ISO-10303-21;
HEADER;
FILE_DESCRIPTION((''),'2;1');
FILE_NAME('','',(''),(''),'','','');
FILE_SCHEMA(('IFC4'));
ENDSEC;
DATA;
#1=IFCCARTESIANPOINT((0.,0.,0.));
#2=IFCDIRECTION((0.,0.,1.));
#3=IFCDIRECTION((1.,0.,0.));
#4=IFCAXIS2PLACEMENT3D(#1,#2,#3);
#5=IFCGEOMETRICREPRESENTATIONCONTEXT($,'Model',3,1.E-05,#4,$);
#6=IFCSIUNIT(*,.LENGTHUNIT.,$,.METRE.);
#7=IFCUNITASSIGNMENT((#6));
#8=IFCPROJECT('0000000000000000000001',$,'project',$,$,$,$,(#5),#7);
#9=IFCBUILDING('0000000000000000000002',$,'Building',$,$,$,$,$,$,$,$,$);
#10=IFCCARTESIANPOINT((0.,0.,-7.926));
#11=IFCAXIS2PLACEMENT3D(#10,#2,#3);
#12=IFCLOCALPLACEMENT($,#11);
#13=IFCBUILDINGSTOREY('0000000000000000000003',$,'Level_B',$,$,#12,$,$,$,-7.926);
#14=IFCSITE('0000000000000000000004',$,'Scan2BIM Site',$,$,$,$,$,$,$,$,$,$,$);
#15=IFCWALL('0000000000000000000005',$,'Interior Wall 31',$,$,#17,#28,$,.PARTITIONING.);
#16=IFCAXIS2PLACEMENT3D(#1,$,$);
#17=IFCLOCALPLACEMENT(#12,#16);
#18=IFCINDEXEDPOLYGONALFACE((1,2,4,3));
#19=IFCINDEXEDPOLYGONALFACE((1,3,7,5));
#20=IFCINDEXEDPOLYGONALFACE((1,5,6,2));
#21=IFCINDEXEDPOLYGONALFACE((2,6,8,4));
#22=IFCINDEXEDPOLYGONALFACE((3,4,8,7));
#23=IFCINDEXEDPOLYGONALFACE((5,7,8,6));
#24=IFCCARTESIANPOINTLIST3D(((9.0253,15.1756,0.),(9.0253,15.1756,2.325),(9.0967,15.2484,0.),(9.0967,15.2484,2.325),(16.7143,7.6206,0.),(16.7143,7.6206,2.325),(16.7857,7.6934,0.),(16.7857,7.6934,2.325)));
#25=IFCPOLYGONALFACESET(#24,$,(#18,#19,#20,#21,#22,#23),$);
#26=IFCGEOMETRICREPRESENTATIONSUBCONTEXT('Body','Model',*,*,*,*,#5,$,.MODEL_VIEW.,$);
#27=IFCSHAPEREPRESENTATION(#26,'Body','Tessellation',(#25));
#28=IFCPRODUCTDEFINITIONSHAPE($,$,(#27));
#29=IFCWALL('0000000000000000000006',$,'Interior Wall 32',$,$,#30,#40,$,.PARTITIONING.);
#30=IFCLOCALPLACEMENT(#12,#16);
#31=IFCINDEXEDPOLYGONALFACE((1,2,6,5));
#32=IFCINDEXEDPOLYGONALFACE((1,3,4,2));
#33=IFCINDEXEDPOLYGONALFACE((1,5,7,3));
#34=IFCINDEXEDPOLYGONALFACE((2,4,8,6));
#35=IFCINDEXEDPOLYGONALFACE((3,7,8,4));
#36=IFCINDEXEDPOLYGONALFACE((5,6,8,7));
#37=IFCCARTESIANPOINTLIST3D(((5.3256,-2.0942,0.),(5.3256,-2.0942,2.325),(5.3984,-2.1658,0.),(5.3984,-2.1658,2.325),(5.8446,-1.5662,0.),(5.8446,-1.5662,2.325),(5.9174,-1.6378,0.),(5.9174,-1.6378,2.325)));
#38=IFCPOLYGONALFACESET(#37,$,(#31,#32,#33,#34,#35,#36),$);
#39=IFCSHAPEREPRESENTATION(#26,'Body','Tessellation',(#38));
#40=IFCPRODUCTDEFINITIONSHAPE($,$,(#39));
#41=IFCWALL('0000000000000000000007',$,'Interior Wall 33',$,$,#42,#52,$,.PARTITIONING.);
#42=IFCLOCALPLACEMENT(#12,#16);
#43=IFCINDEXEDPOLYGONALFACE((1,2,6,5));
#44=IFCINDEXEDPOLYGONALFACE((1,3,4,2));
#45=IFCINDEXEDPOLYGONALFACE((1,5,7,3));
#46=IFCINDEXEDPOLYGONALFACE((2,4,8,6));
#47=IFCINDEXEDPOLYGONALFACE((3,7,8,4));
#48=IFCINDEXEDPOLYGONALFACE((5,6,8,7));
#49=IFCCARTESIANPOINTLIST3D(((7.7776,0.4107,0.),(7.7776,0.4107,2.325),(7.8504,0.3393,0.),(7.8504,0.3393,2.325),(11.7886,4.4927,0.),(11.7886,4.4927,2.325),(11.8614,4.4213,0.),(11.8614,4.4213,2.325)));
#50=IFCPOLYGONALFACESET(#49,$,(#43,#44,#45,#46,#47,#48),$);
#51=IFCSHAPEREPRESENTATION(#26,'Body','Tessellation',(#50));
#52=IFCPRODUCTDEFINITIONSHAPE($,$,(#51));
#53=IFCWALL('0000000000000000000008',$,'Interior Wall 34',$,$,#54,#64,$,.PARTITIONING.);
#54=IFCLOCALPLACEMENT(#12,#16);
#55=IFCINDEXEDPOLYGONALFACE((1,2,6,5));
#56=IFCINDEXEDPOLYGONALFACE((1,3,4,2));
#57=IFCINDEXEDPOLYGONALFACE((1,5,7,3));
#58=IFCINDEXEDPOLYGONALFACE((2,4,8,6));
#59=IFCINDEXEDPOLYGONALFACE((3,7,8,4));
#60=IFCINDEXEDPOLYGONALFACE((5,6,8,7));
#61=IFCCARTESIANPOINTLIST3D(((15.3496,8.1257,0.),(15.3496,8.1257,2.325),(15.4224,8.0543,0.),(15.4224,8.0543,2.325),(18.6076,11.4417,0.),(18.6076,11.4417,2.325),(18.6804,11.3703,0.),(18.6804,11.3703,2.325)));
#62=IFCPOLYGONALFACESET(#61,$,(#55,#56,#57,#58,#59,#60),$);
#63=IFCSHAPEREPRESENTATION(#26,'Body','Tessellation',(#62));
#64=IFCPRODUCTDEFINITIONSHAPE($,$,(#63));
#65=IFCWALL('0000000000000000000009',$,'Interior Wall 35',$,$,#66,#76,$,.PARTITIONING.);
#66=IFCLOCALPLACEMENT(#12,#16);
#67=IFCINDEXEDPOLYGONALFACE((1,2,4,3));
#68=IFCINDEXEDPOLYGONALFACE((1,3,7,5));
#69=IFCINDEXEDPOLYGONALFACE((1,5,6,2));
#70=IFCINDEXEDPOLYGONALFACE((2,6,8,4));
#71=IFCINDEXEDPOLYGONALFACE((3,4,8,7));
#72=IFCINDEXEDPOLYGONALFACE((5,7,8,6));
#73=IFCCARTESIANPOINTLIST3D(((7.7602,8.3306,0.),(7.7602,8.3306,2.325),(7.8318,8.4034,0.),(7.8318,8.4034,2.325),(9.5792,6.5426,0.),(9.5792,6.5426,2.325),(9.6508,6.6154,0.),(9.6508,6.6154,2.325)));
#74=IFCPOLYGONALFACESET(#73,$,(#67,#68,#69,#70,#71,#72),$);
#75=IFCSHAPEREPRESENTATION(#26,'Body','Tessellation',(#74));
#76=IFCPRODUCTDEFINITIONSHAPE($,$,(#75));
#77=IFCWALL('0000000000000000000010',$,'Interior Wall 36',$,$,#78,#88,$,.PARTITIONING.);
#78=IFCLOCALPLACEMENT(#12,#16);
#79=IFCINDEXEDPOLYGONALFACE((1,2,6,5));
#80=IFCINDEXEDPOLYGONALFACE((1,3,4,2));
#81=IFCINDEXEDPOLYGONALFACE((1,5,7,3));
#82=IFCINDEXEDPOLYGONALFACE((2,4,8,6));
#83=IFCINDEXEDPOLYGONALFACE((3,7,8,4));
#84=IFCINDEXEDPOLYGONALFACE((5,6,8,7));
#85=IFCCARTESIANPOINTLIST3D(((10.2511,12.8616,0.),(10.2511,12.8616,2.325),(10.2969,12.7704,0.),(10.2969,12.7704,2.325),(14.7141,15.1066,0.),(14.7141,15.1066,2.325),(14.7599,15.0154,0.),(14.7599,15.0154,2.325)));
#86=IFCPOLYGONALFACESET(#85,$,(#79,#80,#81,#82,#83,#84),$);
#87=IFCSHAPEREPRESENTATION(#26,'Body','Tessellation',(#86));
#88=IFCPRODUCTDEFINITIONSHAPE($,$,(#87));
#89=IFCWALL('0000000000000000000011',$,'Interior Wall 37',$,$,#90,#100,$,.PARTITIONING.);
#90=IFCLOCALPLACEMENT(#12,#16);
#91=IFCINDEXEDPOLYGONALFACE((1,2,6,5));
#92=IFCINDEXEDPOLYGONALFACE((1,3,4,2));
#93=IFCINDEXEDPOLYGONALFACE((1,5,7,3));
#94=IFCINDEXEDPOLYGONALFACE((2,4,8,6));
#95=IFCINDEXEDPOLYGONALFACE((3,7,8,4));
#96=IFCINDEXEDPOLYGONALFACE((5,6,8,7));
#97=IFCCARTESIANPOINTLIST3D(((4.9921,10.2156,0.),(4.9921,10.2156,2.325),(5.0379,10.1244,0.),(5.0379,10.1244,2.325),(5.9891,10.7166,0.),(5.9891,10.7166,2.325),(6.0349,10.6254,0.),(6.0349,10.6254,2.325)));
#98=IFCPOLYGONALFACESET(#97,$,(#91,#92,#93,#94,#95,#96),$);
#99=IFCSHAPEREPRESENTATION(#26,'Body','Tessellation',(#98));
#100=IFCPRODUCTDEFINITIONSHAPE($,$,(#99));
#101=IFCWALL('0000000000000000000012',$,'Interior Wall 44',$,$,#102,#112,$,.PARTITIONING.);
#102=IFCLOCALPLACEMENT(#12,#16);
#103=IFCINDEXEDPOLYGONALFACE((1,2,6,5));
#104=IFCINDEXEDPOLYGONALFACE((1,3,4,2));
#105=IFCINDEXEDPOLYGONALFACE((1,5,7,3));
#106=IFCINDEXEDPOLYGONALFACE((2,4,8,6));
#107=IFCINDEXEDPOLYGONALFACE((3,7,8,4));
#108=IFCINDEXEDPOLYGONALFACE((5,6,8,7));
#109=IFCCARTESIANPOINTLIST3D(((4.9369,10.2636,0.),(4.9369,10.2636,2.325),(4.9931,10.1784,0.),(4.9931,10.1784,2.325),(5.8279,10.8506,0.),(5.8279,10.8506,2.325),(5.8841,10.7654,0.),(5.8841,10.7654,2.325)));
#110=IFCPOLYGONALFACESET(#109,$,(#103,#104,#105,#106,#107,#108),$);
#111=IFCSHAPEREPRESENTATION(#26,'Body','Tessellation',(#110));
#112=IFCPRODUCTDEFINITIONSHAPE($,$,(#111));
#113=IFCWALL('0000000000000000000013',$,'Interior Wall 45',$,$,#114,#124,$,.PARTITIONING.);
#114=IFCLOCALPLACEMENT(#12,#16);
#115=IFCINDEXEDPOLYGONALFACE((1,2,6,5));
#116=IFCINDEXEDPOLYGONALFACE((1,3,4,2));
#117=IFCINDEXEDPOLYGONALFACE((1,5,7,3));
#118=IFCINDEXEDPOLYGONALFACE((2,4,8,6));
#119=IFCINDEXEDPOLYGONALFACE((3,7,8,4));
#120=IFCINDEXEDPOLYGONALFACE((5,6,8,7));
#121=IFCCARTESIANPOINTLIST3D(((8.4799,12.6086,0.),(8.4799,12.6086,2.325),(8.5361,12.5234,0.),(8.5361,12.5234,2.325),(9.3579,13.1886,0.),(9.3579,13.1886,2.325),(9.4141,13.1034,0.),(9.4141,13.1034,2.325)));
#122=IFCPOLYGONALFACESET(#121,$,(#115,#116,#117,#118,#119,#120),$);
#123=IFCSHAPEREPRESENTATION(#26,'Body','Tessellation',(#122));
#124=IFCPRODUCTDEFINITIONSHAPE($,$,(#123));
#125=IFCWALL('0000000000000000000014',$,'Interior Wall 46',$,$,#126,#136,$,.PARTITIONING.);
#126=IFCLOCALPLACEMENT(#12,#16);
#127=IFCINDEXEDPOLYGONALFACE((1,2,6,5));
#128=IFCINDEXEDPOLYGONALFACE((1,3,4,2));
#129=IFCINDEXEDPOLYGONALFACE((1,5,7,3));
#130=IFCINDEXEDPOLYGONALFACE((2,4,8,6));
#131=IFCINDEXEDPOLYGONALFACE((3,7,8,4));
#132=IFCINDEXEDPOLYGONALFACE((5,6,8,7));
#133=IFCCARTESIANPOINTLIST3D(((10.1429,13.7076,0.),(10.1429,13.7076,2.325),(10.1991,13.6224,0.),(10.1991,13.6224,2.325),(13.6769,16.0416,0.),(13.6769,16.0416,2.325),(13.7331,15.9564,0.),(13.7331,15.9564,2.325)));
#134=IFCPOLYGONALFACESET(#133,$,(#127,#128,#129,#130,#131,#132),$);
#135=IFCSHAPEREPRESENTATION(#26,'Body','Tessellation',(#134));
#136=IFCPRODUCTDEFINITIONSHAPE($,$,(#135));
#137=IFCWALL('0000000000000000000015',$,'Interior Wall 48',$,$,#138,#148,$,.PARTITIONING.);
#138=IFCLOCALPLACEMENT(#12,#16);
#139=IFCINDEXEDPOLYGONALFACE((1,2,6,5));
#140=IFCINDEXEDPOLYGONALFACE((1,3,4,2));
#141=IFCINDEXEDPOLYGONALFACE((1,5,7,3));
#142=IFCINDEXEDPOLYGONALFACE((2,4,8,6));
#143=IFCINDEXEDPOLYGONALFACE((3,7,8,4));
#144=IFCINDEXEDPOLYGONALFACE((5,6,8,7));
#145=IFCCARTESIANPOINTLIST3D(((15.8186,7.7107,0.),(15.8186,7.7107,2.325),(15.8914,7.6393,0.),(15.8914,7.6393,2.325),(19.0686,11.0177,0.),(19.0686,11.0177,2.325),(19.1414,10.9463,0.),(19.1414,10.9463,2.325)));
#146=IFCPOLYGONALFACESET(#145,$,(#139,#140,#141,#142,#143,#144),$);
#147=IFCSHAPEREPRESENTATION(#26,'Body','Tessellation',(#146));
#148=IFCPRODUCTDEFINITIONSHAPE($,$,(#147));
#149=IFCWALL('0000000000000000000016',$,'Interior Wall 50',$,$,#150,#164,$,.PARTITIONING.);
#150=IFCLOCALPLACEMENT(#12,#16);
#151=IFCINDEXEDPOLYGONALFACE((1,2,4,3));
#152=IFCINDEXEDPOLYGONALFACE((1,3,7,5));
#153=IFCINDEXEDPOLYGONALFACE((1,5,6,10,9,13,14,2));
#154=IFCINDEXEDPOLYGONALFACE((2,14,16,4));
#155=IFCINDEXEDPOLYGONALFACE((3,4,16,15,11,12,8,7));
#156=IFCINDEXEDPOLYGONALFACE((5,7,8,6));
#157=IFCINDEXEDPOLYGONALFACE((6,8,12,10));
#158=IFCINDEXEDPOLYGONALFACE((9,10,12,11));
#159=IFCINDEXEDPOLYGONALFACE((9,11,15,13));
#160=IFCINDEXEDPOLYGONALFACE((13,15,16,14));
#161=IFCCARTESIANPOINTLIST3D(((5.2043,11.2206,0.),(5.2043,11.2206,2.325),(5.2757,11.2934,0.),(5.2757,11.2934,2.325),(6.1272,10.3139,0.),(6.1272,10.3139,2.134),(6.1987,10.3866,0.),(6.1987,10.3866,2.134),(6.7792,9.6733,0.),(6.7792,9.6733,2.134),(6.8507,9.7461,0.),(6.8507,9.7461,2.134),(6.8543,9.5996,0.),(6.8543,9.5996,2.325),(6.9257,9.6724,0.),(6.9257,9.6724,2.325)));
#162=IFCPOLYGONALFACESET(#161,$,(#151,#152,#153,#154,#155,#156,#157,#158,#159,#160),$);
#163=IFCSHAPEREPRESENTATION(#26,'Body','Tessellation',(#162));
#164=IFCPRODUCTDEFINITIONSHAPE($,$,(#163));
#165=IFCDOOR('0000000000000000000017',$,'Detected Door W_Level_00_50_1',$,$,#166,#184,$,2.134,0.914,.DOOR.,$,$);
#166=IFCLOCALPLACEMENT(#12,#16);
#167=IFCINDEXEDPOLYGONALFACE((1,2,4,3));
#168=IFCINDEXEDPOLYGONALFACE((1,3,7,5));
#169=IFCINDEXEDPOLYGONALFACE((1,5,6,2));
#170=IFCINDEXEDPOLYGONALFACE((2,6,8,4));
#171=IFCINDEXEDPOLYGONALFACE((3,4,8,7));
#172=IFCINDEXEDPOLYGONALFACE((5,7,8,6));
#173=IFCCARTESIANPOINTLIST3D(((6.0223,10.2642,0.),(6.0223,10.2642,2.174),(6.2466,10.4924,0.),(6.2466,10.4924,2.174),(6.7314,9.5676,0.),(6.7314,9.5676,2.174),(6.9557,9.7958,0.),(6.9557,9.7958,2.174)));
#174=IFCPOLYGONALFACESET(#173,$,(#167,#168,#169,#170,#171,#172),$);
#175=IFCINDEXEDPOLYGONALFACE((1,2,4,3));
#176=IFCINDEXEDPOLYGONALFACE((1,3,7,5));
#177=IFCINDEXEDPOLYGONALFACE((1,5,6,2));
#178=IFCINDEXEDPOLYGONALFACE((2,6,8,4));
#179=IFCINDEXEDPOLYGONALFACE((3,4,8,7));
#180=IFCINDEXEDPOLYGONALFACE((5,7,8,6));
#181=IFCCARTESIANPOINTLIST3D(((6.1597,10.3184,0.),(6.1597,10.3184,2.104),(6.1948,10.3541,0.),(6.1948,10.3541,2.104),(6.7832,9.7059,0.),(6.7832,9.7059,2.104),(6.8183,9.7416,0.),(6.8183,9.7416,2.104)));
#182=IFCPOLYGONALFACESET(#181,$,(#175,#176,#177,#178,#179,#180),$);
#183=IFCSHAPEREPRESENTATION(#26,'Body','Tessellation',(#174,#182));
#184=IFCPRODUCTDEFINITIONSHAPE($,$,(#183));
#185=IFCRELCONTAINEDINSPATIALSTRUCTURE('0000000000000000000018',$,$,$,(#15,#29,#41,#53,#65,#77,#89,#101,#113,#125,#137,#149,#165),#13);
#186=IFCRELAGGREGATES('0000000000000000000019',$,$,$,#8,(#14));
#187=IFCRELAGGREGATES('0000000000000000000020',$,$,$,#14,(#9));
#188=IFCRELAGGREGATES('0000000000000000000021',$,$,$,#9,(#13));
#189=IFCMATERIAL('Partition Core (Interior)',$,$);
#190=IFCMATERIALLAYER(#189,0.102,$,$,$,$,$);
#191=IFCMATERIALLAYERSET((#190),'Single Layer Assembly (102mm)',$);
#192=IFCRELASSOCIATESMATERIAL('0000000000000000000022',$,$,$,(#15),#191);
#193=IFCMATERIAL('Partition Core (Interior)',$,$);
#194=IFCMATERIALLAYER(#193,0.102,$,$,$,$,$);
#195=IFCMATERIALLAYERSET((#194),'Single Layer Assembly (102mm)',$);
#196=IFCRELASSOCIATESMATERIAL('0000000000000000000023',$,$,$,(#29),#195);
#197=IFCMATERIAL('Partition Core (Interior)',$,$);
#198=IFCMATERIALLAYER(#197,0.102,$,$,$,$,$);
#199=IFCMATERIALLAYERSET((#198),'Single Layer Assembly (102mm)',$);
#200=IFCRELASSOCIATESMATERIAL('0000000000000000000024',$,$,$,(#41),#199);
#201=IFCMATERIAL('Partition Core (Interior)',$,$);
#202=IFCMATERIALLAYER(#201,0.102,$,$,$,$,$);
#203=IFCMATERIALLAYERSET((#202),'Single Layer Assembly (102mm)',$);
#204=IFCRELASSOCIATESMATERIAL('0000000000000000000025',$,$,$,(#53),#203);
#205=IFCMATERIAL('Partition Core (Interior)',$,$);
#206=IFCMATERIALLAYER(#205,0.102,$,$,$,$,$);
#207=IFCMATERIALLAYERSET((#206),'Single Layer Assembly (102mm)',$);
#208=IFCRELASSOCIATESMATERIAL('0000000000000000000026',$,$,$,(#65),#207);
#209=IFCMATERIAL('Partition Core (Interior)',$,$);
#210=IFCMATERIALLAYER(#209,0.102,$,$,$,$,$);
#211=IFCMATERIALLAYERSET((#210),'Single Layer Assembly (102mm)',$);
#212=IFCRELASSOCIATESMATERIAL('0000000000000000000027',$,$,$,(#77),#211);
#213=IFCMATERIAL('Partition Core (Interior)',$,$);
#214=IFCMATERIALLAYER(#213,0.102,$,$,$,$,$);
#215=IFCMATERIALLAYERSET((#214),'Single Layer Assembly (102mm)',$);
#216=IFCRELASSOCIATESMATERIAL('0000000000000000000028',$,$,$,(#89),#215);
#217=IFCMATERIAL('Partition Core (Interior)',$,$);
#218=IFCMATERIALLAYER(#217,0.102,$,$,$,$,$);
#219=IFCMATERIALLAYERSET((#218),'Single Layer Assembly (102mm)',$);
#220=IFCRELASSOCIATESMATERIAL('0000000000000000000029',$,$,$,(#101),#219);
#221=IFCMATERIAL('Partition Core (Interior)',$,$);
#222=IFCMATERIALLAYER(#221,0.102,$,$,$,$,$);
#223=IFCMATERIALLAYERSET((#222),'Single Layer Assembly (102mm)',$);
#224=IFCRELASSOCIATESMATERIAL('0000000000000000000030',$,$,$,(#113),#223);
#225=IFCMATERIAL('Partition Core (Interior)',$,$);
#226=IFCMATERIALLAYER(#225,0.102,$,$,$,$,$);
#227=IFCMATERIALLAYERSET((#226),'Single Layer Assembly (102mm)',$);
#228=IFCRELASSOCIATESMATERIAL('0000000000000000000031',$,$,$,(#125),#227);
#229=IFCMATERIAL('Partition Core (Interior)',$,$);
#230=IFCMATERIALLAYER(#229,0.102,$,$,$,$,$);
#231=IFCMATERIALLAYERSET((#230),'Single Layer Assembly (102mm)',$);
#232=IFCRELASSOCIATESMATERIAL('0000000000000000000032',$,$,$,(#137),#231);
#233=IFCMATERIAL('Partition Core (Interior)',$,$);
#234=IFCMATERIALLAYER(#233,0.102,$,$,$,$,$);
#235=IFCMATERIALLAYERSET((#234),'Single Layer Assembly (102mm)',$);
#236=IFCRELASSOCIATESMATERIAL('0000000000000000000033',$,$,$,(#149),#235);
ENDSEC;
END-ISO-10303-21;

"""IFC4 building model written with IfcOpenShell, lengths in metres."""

from ifc_helpers import new_model, si_unit, frame, origin, origin_with_axes, place, context, subcontext, project, spatial, rectangle, extrude, material, layer, layer_set, element, fill, save


model = new_model("IFC4")

# Units and contexts
model_context = context("Model", 3, precision=1e-05, world=origin_with_axes())
body_context = subcontext(model_context, "Body", "Model", "MODEL_VIEW")
ifc_project = project(units=[si_unit("LENGTHUNIT", "METRE")], contexts=[model_context])

# Site, building, storey
site = spatial("IfcSite", under=ifc_project, Name="Scan2BIM Site")
building = spatial("IfcBuilding", under=site, Name="Building")
storey_placement = place(None, frame((0.0, 0.0, -7.926), z_axis=(0.0, 0.0, 1.0), x_axis=(1.0, 0.0, 0.0)))
storey = spatial("IfcBuildingStorey", under=building, at=storey_placement, Name="Level_B", Elevation=-7.926)

# Walls
ifc_material_1 = material(Name="Partition Core (Interior)")
ifc_layer_1 = layer(ifc_material_1, 0.102)
ifc_layer_set_1 = layer_set([ifc_layer_1], Name="Single Layer Assembly (102mm)")
wall_1_placement = place(storey_placement, frame((12.9055, 11.4345, 0.0), z_axis=(0.0, 0.0, 1.0), x_axis=(-0.713295, 0.700864, 0.0)))
element("IfcWall", 1, at=wall_1_placement, inside=storey, material=ifc_layer_set_1, Name="Interior Wall 31", PredefinedType="PARTITIONING", context=body_context, shape_type="SweptSolid", body=[
    extrude(rectangle(XDim=10.7796, YDim=0.102), origin(), (0.0, 0.0, 1.0), 2.325),
])
ifc_material_2 = material(Name="Partition Core (Interior)")
ifc_layer_2 = layer(ifc_material_2, 0.102)
ifc_layer_set_2 = layer_set([ifc_layer_2], Name="Single Layer Assembly (102mm)")
wall_2_placement = place(storey_placement, frame((5.6215, -1.866, 0.0), z_axis=(0.0, 0.0, 1.0), x_axis=(0.701003, 0.713159, 0.0)))
element("IfcWall", 2, at=wall_2_placement, inside=storey, material=ifc_layer_set_2, Name="Interior Wall 32", PredefinedType="PARTITIONING", context=body_context, shape_type="SweptSolid", body=[
    extrude(rectangle(XDim=0.7404, YDim=0.102), origin(), (0.0, 0.0, 1.0), 2.325),
])
ifc_material_3 = material(Name="Partition Core (Interior)")
ifc_layer_3 = layer(ifc_material_3, 0.102)
ifc_layer_set_3 = layer_set([ifc_layer_3], Name="Single Layer Assembly (102mm)")
wall_3_placement = place(storey_placement, frame((9.8195, 2.416, 0.0), z_axis=(0.0, 0.0, 1.0), x_axis=(0.700876, 0.713283, 0.0)))
element("IfcWall", 3, at=wall_3_placement, inside=storey, material=ifc_layer_set_3, Name="Interior Wall 33", PredefinedType="PARTITIONING", context=body_context, shape_type="SweptSolid", body=[
    extrude(rectangle(XDim=5.7228, YDim=0.102), origin(), (0.0, 0.0, 1.0), 2.325),
])
ifc_material_4 = material(Name="Partition Core (Interior)")
ifc_layer_4 = layer(ifc_material_4, 0.102)
ifc_layer_set_4 = layer_set([ifc_layer_4], Name="Single Layer Assembly (102mm)")
wall_4_placement = place(storey_placement, frame((17.015, 9.748, 0.0), z_axis=(0.0, 0.0, 1.0), x_axis=(0.700841, 0.713318, 0.0)))
element("IfcWall", 4, at=wall_4_placement, inside=storey, material=ifc_layer_set_4, Name="Interior Wall 34", PredefinedType="PARTITIONING", context=body_context, shape_type="SweptSolid", body=[
    extrude(rectangle(XDim=4.6487, YDim=0.102), origin(), (0.0, 0.0, 1.0), 2.325),
])
ifc_material_5 = material(Name="Partition Core (Interior)")
ifc_layer_5 = layer(ifc_material_5, 0.102)
ifc_layer_set_5 = layer_set([ifc_layer_5], Name="Single Layer Assembly (102mm)")
wall_5_placement = place(storey_placement, frame((8.7055, 7.473, 0.0), z_axis=(0.0, 0.0, 1.0), x_axis=(0.713158, -0.701004, 0.0)))
element("IfcWall", 5, at=wall_5_placement, inside=storey, material=ifc_layer_set_5, Name="Interior Wall 35", PredefinedType="PARTITIONING", context=body_context, shape_type="SweptSolid", body=[
    extrude(rectangle(XDim=2.5506, YDim=0.102), origin(), (0.0, 0.0, 1.0), 2.325),
])
ifc_material_6 = material(Name="Partition Core (Interior)")
ifc_layer_6 = layer(ifc_material_6, 0.102)
ifc_layer_set_6 = layer_set([ifc_layer_6], Name="Single Layer Assembly (102mm)")
wall_6_placement = place(storey_placement, frame((12.5055, 13.9385, 0.0), z_axis=(0.0, 0.0, 1.0), x_axis=(-0.893344, -0.449374, 0.0)))
element("IfcWall", 6, at=wall_6_placement, inside=storey, material=ifc_layer_set_6, Name="Interior Wall 36", PredefinedType="PARTITIONING", context=body_context, shape_type="SweptSolid", body=[
    extrude(rectangle(XDim=4.9958, YDim=0.102), origin(), (0.0, 0.0, 1.0), 2.325),
])
ifc_material_7 = material(Name="Partition Core (Interior)")
ifc_layer_7 = layer(ifc_material_7, 0.102)
ifc_layer_set_7 = layer_set([ifc_layer_7], Name="Single Layer Assembly (102mm)")
wall_7_placement = place(storey_placement, frame((5.5135, 10.4205, 0.0), z_axis=(0.0, 0.0, 1.0), x_axis=(-0.893529, -0.449005, 0.0)))
element("IfcWall", 7, at=wall_7_placement, inside=storey, material=ifc_layer_set_7, Name="Interior Wall 37", PredefinedType="PARTITIONING", context=body_context, shape_type="SweptSolid", body=[
    extrude(rectangle(XDim=1.1158, YDim=0.102), origin(), (0.0, 0.0, 1.0), 2.325),
])
ifc_material_8 = material(Name="Partition Core (Interior)")
ifc_layer_8 = layer(ifc_material_8, 0.102)
ifc_layer_set_8 = layer_set([ifc_layer_8], Name="Single Layer Assembly (102mm)")
wall_8_placement = place(storey_placement, frame((5.4105, 10.5145, 0.0), z_axis=(0.0, 0.0, 1.0), x_axis=(0.835066, 0.55015, 0.0)))
element("IfcWall", 8, at=wall_8_placement, inside=storey, material=ifc_layer_set_8, Name="Interior Wall 44", PredefinedType="PARTITIONING", context=body_context, shape_type="SweptSolid", body=[
    extrude(rectangle(XDim=1.067, YDim=0.102), origin(), (0.0, 0.0, 1.0), 2.325),
])
ifc_material_9 = material(Name="Partition Core (Interior)")
ifc_layer_9 = layer(ifc_material_9, 0.102)
ifc_layer_set_9 = layer_set([ifc_layer_9], Name="Single Layer Assembly (102mm)")
wall_9_placement = place(storey_placement, frame((8.947, 12.856, 0.0), z_axis=(0.0, 0.0, 1.0), x_axis=(0.834382, 0.551186, 0.0)))
element("IfcWall", 9, at=wall_9_placement, inside=storey, material=ifc_layer_set_9, Name="Interior Wall 45", PredefinedType="PARTITIONING", context=body_context, shape_type="SweptSolid", body=[
    extrude(rectangle(XDim=1.0523, YDim=0.102), origin(), (0.0, 0.0, 1.0), 2.325),
])
ifc_material_10 = material(Name="Partition Core (Interior)")
ifc_layer_10 = layer(ifc_material_10, 0.102)
ifc_layer_set_10 = layer_set([ifc_layer_10], Name="Single Layer Assembly (102mm)")
wall_10_placement = place(storey_placement, frame((11.938, 14.832, 0.0), z_axis=(0.0, 0.0, 1.0), x_axis=(0.83444, 0.551099, 0.0)))
element("IfcWall", 10, at=wall_10_placement, inside=storey, material=ifc_layer_set_10, Name="Interior Wall 46", PredefinedType="PARTITIONING", context=body_context, shape_type="SweptSolid", body=[
    extrude(rectangle(XDim=4.2352, YDim=0.102), origin(), (0.0, 0.0, 1.0), 2.325),
])
ifc_material_11 = material(Name="Partition Core (Interior)")
ifc_layer_11 = layer(ifc_material_11, 0.102)
ifc_layer_set_11 = layer_set([ifc_layer_11], Name="Single Layer Assembly (102mm)")
wall_11_placement = place(storey_placement, frame((17.48, 9.3285, 0.0), z_axis=(0.0, 0.0, 1.0), x_axis=(-0.700933, -0.713227, 0.0)))
element("IfcWall", 11, at=wall_11_placement, inside=storey, material=ifc_layer_set_11, Name="Interior Wall 48", PredefinedType="PARTITIONING", context=body_context, shape_type="SweptSolid", body=[
    extrude(rectangle(XDim=4.6367, YDim=0.102), origin(), (0.0, 0.0, 1.0), 2.325),
])

# Wall, opening, door
ifc_material_12 = material(Name="Partition Core (Interior)")
ifc_layer_12 = layer(ifc_material_12, 0.102)
ifc_layer_set_12 = layer_set([ifc_layer_12], Name="Single Layer Assembly (102mm)")
wall_12_placement = place(storey_placement, frame((6.065, 10.4465, 0.0), z_axis=(0.0, 0.0, 1.0), x_axis=(0.713348, -0.70081, 0.0)))
wall_12 = element("IfcWall", 12, at=wall_12_placement, inside=storey, material=ifc_layer_set_12, Name="Interior Wall 50", PredefinedType="PARTITIONING", context=body_context, shape_type="SweptSolid", body=[
    extrude(rectangle(XDim=2.313, YDim=0.102), origin(), (0.0, 0.0, 1.0), 2.325),
])
opening_1_placement = place(None, frame((6.489, 10.03, -7.926), z_axis=(0.0, 0.0, 1.0), x_axis=(0.713348, -0.70081, 0.0)))
opening_1 = element("IfcOpeningElement", 13, at=opening_1_placement, cuts=wall_12, PredefinedType="OPENING", context=body_context, shape_type="SweptSolid", body=[
    extrude(rectangle(XDim=0.914, YDim=0.202), origin(), (0.0, 0.0, 1.0), 2.134),
])
door_1_placement = place(opening_1_placement, frame((0.0, 0.0, 0.0), z_axis=(0.0, 0.0, 1.0), x_axis=(1.0, 0.0, 0.0)))
door_1 = element("IfcDoor", 14, at=door_1_placement, inside=storey, Name="Detected Door W_Level_00_50_1", OverallHeight=2.134, OverallWidth=0.914, PredefinedType="DOOR", context=body_context, shape_type="SweptSolid", body=[
    extrude(rectangle(XDim=0.994, YDim=0.32), origin(), (0.0, 0.0, 1.0), 2.174),
    extrude(rectangle(XDim=0.874, YDim=0.05), origin(), (0.0, 0.0, 1.0), 2.104),
])
fill(opening_1, door_1)

save(model, "model.ifc")
